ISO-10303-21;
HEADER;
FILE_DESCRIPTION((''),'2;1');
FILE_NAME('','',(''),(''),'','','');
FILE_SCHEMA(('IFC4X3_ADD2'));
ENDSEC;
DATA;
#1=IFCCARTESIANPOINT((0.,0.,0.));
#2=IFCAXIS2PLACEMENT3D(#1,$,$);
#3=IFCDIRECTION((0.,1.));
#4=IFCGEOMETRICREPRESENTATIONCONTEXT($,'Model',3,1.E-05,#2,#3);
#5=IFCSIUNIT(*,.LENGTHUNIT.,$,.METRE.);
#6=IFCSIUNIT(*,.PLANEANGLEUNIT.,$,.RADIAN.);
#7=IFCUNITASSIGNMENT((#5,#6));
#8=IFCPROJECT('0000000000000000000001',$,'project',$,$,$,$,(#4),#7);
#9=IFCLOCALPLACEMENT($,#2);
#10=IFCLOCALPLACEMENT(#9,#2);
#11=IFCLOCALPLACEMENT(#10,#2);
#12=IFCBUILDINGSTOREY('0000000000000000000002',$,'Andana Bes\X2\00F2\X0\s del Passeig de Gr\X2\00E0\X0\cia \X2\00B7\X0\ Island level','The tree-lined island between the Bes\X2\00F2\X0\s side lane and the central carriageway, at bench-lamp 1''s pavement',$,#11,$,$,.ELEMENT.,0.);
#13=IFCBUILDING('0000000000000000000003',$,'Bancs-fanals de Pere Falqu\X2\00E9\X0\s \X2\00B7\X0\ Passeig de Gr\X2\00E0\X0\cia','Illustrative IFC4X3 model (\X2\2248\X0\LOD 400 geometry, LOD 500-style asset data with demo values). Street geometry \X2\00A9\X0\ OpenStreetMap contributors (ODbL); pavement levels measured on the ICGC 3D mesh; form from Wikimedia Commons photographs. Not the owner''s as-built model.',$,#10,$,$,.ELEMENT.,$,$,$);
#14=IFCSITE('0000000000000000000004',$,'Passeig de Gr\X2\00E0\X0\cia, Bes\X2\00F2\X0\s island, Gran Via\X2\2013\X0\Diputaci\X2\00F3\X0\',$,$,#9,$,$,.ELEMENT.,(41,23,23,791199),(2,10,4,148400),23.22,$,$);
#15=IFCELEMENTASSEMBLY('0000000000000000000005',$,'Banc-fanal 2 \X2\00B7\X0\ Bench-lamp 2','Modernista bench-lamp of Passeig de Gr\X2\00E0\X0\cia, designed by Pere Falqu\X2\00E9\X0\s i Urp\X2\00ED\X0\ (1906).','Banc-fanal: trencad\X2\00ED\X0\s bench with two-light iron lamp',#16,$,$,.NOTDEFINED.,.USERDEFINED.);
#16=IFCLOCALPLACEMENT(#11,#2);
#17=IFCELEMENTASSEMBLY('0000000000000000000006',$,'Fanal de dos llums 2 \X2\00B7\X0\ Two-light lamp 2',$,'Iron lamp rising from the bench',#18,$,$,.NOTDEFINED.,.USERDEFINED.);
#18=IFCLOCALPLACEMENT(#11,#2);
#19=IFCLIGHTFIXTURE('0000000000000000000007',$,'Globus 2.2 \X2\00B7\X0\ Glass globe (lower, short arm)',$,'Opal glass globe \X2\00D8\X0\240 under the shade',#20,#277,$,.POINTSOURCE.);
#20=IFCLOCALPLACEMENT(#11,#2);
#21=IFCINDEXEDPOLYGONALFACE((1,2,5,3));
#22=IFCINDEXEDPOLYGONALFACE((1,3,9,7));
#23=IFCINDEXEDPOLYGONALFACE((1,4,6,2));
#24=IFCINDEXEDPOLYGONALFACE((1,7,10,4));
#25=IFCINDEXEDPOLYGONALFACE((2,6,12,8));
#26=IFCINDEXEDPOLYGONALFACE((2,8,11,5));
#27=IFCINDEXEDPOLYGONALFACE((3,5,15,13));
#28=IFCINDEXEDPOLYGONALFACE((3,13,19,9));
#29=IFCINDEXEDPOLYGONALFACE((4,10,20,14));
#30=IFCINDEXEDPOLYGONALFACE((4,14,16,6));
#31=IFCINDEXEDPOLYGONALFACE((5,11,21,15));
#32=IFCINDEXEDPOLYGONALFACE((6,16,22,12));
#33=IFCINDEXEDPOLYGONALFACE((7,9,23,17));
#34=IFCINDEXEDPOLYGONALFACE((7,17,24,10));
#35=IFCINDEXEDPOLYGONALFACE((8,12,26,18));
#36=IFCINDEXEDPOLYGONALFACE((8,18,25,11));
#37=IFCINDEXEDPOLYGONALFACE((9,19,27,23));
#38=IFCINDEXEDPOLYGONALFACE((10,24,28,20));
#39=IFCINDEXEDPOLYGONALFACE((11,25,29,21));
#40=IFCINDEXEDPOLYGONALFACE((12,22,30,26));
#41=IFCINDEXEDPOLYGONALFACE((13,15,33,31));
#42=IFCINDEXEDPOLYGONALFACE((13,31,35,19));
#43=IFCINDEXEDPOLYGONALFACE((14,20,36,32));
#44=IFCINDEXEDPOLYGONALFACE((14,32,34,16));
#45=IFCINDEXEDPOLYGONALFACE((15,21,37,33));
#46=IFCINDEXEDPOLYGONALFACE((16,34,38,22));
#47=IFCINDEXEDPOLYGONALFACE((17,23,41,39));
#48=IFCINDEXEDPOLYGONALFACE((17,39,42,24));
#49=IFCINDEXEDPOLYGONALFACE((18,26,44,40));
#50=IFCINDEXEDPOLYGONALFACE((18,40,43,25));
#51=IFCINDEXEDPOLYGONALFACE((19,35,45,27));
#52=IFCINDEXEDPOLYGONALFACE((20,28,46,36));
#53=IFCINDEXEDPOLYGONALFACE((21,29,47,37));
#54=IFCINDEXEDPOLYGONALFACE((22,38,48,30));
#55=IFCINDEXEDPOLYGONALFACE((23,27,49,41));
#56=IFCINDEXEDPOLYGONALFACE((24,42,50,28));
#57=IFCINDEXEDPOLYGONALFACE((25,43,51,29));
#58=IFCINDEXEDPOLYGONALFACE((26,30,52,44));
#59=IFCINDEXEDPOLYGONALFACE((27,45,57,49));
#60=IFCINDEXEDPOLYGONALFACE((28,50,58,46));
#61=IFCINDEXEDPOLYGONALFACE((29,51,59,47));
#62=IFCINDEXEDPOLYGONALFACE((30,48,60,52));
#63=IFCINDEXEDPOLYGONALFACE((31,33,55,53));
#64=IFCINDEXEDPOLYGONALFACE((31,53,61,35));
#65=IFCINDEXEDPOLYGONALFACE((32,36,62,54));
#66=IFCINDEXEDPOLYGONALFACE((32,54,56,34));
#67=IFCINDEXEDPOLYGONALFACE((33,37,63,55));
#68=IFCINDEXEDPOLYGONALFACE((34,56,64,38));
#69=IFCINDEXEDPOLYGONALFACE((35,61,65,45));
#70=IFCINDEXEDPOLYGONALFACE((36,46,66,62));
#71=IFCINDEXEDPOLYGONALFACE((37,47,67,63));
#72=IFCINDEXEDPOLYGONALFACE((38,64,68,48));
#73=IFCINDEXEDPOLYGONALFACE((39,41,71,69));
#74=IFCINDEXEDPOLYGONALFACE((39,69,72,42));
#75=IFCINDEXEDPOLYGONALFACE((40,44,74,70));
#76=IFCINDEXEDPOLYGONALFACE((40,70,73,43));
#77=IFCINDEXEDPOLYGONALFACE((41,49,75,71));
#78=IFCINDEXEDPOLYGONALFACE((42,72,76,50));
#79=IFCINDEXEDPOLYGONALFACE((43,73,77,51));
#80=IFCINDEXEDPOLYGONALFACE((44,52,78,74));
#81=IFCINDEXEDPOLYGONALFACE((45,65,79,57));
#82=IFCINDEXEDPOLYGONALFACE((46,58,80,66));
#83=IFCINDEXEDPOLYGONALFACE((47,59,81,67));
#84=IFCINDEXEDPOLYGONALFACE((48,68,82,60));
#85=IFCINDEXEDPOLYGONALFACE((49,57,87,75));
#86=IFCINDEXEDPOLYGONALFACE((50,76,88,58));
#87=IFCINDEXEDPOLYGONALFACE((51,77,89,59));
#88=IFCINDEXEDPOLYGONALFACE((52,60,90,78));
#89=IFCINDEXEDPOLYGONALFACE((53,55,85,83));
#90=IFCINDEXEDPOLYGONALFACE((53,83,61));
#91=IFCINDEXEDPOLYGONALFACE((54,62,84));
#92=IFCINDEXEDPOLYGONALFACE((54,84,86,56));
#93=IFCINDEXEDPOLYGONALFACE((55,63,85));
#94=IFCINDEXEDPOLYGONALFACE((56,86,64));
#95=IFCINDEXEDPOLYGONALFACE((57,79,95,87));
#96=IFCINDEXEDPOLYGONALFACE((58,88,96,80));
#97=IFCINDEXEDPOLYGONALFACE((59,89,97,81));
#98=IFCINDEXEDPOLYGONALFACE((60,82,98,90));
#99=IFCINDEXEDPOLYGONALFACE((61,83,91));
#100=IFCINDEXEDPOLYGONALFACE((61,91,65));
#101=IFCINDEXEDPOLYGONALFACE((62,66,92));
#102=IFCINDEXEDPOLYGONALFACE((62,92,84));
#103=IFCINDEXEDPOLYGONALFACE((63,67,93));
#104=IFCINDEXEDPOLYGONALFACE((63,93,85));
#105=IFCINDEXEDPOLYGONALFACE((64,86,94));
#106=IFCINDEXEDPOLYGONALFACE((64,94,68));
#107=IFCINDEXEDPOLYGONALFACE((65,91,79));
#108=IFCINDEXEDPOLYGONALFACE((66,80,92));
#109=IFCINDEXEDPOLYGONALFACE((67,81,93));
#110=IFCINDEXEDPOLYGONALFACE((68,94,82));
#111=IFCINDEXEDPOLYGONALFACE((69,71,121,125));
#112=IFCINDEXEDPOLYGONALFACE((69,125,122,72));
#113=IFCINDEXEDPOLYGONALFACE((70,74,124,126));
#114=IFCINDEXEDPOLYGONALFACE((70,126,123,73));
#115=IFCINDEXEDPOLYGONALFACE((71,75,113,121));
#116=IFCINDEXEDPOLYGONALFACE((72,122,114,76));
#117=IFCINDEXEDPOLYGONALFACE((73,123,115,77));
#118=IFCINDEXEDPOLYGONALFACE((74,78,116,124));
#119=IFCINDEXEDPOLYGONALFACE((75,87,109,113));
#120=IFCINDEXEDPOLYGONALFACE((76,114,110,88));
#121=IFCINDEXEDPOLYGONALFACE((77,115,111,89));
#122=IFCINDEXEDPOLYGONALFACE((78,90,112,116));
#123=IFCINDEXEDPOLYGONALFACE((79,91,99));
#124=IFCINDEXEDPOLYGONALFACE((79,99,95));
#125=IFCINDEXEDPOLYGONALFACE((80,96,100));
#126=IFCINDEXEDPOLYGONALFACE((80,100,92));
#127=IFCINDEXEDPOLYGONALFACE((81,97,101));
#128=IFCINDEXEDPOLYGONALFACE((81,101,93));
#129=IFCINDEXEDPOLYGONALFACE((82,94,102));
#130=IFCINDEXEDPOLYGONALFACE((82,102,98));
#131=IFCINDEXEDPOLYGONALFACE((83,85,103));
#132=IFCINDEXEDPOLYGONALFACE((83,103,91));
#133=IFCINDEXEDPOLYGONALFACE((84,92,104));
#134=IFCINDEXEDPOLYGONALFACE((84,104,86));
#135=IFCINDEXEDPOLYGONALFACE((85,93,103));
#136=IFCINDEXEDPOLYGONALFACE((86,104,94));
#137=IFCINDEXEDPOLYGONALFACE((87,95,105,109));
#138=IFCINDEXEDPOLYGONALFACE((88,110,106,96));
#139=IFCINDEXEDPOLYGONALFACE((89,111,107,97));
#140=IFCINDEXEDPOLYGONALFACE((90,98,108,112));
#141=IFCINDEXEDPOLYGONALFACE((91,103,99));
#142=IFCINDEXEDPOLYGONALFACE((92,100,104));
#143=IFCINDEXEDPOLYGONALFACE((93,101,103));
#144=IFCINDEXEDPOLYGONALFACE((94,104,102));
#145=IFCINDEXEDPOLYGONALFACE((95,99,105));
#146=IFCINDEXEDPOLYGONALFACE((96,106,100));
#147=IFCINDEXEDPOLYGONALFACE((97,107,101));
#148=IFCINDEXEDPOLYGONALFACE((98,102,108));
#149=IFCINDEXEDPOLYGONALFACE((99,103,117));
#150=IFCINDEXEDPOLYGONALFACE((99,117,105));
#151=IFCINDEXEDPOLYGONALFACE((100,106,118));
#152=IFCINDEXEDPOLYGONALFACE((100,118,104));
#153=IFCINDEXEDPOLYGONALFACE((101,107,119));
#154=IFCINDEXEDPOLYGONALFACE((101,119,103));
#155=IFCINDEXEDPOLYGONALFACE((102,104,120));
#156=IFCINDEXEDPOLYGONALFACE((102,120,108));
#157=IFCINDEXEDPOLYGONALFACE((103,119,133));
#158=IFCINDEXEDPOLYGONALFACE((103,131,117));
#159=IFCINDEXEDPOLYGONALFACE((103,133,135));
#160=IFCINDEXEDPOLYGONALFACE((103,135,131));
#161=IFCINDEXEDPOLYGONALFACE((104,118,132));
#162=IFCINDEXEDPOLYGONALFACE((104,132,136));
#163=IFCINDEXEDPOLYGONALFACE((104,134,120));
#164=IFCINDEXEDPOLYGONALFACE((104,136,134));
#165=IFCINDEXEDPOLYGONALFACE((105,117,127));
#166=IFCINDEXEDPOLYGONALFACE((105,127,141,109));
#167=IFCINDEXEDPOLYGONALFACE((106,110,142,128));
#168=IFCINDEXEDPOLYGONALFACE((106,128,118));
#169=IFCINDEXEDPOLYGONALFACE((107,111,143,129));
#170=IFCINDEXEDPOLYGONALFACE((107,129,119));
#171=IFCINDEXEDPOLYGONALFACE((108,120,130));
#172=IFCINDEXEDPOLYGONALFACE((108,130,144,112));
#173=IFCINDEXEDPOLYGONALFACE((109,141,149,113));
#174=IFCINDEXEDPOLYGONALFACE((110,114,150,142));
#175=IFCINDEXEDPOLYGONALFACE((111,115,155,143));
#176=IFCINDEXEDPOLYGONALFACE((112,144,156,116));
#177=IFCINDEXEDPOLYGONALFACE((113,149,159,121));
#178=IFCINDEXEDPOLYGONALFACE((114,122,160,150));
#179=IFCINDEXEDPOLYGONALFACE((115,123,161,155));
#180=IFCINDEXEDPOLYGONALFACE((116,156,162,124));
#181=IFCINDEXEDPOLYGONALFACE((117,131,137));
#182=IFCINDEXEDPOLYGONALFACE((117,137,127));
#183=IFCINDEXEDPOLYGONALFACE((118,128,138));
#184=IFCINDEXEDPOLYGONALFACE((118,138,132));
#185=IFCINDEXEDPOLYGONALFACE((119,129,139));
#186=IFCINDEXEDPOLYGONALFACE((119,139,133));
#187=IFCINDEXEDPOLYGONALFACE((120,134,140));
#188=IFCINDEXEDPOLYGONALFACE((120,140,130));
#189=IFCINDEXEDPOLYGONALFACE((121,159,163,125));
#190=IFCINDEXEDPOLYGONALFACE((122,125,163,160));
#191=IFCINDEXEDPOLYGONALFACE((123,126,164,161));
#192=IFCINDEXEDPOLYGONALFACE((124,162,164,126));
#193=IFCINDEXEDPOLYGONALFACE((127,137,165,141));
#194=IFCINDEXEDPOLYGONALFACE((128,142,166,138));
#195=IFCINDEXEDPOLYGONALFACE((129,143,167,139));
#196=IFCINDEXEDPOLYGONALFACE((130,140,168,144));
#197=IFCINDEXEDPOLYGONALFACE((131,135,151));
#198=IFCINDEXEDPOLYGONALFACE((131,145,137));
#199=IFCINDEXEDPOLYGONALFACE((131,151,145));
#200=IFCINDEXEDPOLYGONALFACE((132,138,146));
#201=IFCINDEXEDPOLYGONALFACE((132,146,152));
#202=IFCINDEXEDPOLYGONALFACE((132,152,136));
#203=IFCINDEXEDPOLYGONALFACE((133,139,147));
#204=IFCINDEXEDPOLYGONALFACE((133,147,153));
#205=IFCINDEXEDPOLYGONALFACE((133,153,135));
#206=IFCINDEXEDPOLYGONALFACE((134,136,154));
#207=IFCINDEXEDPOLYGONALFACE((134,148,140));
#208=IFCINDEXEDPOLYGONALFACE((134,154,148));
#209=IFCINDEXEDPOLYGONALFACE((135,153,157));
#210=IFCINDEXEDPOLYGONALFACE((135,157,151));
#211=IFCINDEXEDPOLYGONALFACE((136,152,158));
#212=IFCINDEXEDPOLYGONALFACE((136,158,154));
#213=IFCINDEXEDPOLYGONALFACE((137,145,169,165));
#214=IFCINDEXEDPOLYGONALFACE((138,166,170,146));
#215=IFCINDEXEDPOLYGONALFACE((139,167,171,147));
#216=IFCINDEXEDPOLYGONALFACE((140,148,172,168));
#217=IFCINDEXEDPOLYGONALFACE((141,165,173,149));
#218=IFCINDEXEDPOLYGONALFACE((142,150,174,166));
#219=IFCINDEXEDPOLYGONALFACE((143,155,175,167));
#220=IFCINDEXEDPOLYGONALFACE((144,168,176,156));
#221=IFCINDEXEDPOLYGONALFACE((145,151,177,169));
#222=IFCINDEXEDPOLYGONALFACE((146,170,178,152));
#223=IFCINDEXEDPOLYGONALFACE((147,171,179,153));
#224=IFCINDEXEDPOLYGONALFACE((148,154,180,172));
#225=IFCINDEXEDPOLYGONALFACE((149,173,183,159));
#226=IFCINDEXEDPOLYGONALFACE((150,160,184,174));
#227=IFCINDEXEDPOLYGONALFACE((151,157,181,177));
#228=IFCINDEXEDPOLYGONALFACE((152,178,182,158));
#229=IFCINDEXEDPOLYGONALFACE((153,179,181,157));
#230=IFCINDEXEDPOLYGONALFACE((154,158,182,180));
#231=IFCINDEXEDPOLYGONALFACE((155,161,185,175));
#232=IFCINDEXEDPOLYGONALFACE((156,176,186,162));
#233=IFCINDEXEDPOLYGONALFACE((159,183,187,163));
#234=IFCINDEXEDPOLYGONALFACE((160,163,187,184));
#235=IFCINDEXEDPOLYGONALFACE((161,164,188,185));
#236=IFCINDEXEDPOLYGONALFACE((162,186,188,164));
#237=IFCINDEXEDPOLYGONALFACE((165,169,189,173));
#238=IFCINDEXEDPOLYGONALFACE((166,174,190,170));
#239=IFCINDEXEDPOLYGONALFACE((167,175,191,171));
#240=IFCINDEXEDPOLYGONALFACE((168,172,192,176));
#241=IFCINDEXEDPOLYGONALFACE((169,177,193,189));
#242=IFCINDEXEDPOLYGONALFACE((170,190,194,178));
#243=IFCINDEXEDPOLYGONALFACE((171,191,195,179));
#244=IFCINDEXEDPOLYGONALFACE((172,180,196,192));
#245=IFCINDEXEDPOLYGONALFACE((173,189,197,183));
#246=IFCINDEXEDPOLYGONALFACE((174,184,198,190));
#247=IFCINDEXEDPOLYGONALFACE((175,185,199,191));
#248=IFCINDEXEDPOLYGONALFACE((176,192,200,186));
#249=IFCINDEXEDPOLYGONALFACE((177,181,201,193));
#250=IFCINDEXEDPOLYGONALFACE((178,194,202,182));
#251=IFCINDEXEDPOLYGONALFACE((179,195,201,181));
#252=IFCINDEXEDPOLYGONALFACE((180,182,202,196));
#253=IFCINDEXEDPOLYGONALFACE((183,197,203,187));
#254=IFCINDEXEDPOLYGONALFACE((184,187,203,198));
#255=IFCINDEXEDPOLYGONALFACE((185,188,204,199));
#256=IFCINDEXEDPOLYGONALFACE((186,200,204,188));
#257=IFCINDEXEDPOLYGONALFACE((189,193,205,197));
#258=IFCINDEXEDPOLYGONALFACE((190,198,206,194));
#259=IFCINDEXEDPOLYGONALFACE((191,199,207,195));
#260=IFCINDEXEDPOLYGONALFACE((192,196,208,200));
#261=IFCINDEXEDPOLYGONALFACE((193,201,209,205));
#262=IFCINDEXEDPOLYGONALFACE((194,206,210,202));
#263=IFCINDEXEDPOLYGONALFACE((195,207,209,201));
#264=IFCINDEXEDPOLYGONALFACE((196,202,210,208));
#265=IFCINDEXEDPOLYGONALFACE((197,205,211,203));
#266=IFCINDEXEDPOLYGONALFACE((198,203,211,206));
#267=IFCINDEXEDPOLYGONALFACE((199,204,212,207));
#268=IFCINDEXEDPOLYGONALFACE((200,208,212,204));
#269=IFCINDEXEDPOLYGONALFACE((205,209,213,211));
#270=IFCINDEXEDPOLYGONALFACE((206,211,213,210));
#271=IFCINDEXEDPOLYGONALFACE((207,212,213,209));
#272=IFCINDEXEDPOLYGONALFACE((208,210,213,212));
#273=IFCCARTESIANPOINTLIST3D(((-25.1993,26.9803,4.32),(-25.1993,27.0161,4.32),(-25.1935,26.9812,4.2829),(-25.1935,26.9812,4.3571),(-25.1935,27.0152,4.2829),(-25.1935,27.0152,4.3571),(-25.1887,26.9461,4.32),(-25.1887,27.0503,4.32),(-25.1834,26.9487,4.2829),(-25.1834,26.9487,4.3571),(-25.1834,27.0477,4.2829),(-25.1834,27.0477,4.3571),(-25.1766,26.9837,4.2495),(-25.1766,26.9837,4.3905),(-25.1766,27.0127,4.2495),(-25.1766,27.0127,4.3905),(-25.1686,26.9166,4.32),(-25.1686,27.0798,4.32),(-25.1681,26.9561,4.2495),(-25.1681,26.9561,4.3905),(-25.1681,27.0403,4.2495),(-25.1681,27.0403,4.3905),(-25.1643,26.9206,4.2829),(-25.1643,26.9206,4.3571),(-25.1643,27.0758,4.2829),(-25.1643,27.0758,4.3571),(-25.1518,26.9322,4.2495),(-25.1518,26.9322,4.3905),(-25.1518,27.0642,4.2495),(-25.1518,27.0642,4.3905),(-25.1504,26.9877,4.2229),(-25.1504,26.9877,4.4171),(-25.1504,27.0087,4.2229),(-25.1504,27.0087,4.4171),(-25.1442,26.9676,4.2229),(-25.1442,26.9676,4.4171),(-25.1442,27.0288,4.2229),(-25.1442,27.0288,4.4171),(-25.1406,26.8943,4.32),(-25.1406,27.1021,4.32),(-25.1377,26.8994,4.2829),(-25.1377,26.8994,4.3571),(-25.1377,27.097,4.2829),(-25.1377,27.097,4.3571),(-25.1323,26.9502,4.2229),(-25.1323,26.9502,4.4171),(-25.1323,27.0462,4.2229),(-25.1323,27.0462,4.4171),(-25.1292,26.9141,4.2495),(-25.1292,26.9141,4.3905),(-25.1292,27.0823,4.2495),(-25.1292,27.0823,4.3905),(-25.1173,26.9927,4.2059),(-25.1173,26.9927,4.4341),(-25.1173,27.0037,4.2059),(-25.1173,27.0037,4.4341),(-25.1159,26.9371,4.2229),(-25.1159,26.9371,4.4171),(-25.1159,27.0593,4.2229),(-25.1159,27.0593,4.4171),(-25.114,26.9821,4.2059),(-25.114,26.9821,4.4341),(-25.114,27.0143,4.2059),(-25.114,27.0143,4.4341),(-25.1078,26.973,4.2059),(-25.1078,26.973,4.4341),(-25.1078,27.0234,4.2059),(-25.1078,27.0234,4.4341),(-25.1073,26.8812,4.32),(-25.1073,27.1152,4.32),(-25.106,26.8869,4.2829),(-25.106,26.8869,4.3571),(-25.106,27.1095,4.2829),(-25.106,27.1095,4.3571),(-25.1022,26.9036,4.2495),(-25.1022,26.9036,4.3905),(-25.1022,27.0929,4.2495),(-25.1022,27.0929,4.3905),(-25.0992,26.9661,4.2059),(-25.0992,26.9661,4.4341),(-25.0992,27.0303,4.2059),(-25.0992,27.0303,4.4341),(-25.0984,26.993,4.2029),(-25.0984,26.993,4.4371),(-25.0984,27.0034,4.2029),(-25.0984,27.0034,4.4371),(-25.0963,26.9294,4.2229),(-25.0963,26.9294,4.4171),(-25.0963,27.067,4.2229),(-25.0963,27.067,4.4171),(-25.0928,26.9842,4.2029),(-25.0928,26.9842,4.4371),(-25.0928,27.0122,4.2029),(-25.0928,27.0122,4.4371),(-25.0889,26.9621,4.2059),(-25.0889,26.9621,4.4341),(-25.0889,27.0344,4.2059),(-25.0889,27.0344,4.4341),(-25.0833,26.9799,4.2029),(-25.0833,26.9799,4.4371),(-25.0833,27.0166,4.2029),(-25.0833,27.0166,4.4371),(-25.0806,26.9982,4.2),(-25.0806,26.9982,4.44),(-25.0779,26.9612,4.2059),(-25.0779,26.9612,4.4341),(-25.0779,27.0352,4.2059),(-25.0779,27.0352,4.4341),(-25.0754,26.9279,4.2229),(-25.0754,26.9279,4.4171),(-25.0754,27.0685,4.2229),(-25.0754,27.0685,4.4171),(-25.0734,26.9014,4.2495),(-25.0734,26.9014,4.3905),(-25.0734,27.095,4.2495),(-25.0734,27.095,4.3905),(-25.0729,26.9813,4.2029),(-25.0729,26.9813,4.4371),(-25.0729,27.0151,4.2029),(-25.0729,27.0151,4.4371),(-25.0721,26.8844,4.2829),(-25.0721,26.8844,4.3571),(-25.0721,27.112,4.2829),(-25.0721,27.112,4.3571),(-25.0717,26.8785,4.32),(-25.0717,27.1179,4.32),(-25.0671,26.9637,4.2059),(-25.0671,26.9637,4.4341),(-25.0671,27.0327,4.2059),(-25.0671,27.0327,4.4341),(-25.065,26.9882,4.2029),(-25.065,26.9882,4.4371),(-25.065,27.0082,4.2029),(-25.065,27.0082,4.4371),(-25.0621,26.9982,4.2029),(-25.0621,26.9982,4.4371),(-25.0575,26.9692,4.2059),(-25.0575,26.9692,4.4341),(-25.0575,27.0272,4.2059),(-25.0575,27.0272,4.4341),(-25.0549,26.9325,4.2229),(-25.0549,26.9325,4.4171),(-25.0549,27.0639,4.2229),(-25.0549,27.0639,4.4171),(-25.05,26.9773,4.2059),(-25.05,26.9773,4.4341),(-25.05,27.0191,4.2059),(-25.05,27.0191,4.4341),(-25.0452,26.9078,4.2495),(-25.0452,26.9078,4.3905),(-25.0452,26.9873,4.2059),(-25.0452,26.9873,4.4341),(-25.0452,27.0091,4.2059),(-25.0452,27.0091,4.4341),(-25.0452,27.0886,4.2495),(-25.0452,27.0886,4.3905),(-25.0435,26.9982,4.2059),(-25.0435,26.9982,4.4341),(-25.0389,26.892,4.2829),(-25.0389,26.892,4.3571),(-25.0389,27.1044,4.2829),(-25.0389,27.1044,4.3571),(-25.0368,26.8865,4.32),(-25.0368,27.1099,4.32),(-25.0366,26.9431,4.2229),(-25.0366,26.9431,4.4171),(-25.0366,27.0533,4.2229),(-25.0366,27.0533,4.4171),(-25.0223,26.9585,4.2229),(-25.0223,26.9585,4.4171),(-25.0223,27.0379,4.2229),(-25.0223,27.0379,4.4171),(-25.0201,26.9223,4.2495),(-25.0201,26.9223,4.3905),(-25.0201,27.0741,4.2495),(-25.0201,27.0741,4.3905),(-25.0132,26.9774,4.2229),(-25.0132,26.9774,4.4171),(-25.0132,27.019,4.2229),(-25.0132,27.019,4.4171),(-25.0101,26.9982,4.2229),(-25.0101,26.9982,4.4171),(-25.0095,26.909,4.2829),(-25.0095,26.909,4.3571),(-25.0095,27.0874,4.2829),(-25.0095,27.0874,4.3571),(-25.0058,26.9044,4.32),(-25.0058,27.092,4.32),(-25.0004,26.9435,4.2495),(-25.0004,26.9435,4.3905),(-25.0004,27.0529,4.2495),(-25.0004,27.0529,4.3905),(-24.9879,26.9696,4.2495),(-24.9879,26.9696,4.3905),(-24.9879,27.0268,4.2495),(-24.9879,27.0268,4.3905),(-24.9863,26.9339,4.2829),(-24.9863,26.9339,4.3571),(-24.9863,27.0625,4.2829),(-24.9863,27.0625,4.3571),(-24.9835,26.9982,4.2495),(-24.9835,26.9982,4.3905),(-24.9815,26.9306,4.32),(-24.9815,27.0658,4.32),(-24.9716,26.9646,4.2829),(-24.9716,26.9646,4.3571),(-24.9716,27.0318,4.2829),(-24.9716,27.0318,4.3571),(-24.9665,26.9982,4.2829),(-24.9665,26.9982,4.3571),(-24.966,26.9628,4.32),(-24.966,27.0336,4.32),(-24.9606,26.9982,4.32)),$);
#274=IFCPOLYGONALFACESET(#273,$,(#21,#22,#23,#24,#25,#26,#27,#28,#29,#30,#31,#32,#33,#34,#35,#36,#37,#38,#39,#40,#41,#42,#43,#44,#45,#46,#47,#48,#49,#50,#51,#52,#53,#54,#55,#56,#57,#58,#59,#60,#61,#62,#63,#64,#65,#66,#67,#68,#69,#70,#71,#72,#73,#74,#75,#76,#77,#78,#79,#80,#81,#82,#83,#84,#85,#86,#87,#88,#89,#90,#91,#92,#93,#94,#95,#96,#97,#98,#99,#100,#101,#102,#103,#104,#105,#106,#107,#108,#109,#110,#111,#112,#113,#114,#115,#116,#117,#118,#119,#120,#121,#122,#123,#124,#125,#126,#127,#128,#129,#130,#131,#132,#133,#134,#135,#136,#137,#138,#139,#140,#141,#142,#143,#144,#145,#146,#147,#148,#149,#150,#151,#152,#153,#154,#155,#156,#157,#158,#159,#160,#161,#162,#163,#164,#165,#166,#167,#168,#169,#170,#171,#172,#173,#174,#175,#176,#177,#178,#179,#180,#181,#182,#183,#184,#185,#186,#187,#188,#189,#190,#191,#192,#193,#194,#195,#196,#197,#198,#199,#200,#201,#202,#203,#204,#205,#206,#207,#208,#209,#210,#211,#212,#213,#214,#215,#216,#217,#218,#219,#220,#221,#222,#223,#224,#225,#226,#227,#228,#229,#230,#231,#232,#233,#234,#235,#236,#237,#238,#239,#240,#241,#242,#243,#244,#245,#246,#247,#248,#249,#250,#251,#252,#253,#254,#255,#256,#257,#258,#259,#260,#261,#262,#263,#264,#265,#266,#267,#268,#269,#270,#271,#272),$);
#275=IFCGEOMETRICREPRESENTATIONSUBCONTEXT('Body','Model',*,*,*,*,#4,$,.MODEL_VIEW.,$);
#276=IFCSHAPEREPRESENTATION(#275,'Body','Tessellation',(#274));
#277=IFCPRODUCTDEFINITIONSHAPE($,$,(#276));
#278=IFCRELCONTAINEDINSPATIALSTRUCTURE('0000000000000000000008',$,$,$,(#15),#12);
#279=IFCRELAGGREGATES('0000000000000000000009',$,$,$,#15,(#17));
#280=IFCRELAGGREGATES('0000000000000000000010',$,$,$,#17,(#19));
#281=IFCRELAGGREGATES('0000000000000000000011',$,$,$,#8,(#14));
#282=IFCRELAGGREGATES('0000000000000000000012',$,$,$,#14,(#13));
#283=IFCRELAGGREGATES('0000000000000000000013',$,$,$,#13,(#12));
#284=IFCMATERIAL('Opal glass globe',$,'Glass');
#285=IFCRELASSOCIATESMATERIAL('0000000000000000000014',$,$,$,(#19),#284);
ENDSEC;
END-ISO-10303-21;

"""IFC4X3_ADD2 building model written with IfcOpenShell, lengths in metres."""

from ifc_helpers import new_model, entity, si_unit, direction, origin, place, context, subcontext, project, spatial, material, element, aggregate, save


model = new_model("IFC4X3_ADD2")

# Units and contexts
model_context = context("Model", 3, precision=1e-05, world=origin(), true_north=direction((0.0, 1.0)))
body_context = subcontext(model_context, "Body", "Model", "MODEL_VIEW")
ifc_project = project(units=[si_unit("LENGTHUNIT", "METRE"), si_unit("PLANEANGLEUNIT", "RADIAN")], contexts=[model_context])

# Site, building, storey
site_placement = place(None, origin())
site = spatial("IfcSite", under=ifc_project, at=site_placement, Name="Passeig de Gràcia, Besòs island, Gran Via–Diputació", CompositionType="ELEMENT", RefLatitude=(41, 23, 23, 791199), RefLongitude=(2, 10, 4, 148400), RefElevation=23.22)
building_placement = place(site_placement, origin())
building = spatial("IfcBuilding", under=site, at=building_placement, Name="Bancs-fanals de Pere Falqués · Passeig de Gràcia", Description="Illustrative IFC4X3 model (≈LOD 400 geometry, LOD 500-style asset data with demo values). Street geometry © OpenStreetMap contributors (ODbL); pavement levels measured on the ICGC 3D mesh; form from Wikimedia Commons photographs. Not the owner's as-built model.", CompositionType="ELEMENT")
storey_placement = place(building_placement, origin())
storey = spatial("IfcBuildingStorey", under=building, at=storey_placement, Name="Andana Besòs del Passeig de Gràcia · Island level", Description="The tree-lined island between the Besòs side lane and the central carriageway, at bench-lamp 1's pavement", CompositionType="ELEMENT", Elevation=0.0)

# Element assemblies
assembly_1_placement = place(building_placement, origin())
assembly_1 = element("IfcElementAssembly", 1, at=assembly_1_placement, inside=storey, Name="Banc-fanal 2 · Bench-lamp 2", Description="Modernista bench-lamp of Passeig de Gràcia, designed by Pere Falqués i Urpí (1906).", ObjectType="Banc-fanal: trencadís bench with two-light iron lamp", AssemblyPlace="NOTDEFINED", PredefinedType="USERDEFINED")
assembly_2_placement = place(building_placement, origin())
assembly_2 = element("IfcElementAssembly", 2, at=assembly_2_placement, Name="Fanal de dos llums 2 · Two-light lamp 2", ObjectType="Iron lamp rising from the bench", AssemblyPlace="NOTDEFINED", PredefinedType="USERDEFINED")
aggregate(assembly_1, [assembly_2])

# Shared definitions
ifc_material_1 = material(Name="Opal glass globe", Category="Glass")

# Light fixture
light_fixture_1_placement = place(building_placement, origin())
light_fixture_1 = element("IfcLightFixture", 3, at=light_fixture_1_placement, material=ifc_material_1, Name="Globus 2.2 · Glass globe (lower, short arm)", ObjectType="Opal glass globe Ø240 under the shade", PredefinedType="POINTSOURCE", context=body_context, shape_type="SweptSolid", body=[
    entity("IfcRevolvedAreaSolid", entity("IfcArbitraryClosedProfileDef", "AREA", None, entity("IfcPolyline", [entity("IfcCartesianPoint", [0.0, -0.12]), entity("IfcCartesianPoint", [0.0371, -0.1141]), entity("IfcCartesianPoint", [0.0705, -0.0971]), entity("IfcCartesianPoint", [0.0971, -0.0705]), entity("IfcCartesianPoint", [0.1141, -0.0371]), entity("IfcCartesianPoint", [0.12, 0.0]), entity("IfcCartesianPoint", [0.1141, 0.0371]), entity("IfcCartesianPoint", [0.0971, 0.0705]), entity("IfcCartesianPoint", [0.0705, 0.0971]), entity("IfcCartesianPoint", [0.0371, 0.1141]), entity("IfcCartesianPoint", [0.0, 0.12]), entity("IfcCartesianPoint", [0.0, -0.12])])), entity("IfcAxis2Placement3D", entity("IfcCartesianPoint", [-25.0806, 26.9982, 4.32]), entity("IfcDirection", [0.0, -1.0, 0.0]), entity("IfcDirection", [1.0, 0.0, 0.0])), entity("IfcAxis1Placement", entity("IfcCartesianPoint", [0.0, 0.0, 0.0]), entity("IfcDirection", [0.0, 1.0, 0.0])), 6.283185),
])

aggregate(assembly_2, [light_fixture_1])

save(model, "model.ifc")
